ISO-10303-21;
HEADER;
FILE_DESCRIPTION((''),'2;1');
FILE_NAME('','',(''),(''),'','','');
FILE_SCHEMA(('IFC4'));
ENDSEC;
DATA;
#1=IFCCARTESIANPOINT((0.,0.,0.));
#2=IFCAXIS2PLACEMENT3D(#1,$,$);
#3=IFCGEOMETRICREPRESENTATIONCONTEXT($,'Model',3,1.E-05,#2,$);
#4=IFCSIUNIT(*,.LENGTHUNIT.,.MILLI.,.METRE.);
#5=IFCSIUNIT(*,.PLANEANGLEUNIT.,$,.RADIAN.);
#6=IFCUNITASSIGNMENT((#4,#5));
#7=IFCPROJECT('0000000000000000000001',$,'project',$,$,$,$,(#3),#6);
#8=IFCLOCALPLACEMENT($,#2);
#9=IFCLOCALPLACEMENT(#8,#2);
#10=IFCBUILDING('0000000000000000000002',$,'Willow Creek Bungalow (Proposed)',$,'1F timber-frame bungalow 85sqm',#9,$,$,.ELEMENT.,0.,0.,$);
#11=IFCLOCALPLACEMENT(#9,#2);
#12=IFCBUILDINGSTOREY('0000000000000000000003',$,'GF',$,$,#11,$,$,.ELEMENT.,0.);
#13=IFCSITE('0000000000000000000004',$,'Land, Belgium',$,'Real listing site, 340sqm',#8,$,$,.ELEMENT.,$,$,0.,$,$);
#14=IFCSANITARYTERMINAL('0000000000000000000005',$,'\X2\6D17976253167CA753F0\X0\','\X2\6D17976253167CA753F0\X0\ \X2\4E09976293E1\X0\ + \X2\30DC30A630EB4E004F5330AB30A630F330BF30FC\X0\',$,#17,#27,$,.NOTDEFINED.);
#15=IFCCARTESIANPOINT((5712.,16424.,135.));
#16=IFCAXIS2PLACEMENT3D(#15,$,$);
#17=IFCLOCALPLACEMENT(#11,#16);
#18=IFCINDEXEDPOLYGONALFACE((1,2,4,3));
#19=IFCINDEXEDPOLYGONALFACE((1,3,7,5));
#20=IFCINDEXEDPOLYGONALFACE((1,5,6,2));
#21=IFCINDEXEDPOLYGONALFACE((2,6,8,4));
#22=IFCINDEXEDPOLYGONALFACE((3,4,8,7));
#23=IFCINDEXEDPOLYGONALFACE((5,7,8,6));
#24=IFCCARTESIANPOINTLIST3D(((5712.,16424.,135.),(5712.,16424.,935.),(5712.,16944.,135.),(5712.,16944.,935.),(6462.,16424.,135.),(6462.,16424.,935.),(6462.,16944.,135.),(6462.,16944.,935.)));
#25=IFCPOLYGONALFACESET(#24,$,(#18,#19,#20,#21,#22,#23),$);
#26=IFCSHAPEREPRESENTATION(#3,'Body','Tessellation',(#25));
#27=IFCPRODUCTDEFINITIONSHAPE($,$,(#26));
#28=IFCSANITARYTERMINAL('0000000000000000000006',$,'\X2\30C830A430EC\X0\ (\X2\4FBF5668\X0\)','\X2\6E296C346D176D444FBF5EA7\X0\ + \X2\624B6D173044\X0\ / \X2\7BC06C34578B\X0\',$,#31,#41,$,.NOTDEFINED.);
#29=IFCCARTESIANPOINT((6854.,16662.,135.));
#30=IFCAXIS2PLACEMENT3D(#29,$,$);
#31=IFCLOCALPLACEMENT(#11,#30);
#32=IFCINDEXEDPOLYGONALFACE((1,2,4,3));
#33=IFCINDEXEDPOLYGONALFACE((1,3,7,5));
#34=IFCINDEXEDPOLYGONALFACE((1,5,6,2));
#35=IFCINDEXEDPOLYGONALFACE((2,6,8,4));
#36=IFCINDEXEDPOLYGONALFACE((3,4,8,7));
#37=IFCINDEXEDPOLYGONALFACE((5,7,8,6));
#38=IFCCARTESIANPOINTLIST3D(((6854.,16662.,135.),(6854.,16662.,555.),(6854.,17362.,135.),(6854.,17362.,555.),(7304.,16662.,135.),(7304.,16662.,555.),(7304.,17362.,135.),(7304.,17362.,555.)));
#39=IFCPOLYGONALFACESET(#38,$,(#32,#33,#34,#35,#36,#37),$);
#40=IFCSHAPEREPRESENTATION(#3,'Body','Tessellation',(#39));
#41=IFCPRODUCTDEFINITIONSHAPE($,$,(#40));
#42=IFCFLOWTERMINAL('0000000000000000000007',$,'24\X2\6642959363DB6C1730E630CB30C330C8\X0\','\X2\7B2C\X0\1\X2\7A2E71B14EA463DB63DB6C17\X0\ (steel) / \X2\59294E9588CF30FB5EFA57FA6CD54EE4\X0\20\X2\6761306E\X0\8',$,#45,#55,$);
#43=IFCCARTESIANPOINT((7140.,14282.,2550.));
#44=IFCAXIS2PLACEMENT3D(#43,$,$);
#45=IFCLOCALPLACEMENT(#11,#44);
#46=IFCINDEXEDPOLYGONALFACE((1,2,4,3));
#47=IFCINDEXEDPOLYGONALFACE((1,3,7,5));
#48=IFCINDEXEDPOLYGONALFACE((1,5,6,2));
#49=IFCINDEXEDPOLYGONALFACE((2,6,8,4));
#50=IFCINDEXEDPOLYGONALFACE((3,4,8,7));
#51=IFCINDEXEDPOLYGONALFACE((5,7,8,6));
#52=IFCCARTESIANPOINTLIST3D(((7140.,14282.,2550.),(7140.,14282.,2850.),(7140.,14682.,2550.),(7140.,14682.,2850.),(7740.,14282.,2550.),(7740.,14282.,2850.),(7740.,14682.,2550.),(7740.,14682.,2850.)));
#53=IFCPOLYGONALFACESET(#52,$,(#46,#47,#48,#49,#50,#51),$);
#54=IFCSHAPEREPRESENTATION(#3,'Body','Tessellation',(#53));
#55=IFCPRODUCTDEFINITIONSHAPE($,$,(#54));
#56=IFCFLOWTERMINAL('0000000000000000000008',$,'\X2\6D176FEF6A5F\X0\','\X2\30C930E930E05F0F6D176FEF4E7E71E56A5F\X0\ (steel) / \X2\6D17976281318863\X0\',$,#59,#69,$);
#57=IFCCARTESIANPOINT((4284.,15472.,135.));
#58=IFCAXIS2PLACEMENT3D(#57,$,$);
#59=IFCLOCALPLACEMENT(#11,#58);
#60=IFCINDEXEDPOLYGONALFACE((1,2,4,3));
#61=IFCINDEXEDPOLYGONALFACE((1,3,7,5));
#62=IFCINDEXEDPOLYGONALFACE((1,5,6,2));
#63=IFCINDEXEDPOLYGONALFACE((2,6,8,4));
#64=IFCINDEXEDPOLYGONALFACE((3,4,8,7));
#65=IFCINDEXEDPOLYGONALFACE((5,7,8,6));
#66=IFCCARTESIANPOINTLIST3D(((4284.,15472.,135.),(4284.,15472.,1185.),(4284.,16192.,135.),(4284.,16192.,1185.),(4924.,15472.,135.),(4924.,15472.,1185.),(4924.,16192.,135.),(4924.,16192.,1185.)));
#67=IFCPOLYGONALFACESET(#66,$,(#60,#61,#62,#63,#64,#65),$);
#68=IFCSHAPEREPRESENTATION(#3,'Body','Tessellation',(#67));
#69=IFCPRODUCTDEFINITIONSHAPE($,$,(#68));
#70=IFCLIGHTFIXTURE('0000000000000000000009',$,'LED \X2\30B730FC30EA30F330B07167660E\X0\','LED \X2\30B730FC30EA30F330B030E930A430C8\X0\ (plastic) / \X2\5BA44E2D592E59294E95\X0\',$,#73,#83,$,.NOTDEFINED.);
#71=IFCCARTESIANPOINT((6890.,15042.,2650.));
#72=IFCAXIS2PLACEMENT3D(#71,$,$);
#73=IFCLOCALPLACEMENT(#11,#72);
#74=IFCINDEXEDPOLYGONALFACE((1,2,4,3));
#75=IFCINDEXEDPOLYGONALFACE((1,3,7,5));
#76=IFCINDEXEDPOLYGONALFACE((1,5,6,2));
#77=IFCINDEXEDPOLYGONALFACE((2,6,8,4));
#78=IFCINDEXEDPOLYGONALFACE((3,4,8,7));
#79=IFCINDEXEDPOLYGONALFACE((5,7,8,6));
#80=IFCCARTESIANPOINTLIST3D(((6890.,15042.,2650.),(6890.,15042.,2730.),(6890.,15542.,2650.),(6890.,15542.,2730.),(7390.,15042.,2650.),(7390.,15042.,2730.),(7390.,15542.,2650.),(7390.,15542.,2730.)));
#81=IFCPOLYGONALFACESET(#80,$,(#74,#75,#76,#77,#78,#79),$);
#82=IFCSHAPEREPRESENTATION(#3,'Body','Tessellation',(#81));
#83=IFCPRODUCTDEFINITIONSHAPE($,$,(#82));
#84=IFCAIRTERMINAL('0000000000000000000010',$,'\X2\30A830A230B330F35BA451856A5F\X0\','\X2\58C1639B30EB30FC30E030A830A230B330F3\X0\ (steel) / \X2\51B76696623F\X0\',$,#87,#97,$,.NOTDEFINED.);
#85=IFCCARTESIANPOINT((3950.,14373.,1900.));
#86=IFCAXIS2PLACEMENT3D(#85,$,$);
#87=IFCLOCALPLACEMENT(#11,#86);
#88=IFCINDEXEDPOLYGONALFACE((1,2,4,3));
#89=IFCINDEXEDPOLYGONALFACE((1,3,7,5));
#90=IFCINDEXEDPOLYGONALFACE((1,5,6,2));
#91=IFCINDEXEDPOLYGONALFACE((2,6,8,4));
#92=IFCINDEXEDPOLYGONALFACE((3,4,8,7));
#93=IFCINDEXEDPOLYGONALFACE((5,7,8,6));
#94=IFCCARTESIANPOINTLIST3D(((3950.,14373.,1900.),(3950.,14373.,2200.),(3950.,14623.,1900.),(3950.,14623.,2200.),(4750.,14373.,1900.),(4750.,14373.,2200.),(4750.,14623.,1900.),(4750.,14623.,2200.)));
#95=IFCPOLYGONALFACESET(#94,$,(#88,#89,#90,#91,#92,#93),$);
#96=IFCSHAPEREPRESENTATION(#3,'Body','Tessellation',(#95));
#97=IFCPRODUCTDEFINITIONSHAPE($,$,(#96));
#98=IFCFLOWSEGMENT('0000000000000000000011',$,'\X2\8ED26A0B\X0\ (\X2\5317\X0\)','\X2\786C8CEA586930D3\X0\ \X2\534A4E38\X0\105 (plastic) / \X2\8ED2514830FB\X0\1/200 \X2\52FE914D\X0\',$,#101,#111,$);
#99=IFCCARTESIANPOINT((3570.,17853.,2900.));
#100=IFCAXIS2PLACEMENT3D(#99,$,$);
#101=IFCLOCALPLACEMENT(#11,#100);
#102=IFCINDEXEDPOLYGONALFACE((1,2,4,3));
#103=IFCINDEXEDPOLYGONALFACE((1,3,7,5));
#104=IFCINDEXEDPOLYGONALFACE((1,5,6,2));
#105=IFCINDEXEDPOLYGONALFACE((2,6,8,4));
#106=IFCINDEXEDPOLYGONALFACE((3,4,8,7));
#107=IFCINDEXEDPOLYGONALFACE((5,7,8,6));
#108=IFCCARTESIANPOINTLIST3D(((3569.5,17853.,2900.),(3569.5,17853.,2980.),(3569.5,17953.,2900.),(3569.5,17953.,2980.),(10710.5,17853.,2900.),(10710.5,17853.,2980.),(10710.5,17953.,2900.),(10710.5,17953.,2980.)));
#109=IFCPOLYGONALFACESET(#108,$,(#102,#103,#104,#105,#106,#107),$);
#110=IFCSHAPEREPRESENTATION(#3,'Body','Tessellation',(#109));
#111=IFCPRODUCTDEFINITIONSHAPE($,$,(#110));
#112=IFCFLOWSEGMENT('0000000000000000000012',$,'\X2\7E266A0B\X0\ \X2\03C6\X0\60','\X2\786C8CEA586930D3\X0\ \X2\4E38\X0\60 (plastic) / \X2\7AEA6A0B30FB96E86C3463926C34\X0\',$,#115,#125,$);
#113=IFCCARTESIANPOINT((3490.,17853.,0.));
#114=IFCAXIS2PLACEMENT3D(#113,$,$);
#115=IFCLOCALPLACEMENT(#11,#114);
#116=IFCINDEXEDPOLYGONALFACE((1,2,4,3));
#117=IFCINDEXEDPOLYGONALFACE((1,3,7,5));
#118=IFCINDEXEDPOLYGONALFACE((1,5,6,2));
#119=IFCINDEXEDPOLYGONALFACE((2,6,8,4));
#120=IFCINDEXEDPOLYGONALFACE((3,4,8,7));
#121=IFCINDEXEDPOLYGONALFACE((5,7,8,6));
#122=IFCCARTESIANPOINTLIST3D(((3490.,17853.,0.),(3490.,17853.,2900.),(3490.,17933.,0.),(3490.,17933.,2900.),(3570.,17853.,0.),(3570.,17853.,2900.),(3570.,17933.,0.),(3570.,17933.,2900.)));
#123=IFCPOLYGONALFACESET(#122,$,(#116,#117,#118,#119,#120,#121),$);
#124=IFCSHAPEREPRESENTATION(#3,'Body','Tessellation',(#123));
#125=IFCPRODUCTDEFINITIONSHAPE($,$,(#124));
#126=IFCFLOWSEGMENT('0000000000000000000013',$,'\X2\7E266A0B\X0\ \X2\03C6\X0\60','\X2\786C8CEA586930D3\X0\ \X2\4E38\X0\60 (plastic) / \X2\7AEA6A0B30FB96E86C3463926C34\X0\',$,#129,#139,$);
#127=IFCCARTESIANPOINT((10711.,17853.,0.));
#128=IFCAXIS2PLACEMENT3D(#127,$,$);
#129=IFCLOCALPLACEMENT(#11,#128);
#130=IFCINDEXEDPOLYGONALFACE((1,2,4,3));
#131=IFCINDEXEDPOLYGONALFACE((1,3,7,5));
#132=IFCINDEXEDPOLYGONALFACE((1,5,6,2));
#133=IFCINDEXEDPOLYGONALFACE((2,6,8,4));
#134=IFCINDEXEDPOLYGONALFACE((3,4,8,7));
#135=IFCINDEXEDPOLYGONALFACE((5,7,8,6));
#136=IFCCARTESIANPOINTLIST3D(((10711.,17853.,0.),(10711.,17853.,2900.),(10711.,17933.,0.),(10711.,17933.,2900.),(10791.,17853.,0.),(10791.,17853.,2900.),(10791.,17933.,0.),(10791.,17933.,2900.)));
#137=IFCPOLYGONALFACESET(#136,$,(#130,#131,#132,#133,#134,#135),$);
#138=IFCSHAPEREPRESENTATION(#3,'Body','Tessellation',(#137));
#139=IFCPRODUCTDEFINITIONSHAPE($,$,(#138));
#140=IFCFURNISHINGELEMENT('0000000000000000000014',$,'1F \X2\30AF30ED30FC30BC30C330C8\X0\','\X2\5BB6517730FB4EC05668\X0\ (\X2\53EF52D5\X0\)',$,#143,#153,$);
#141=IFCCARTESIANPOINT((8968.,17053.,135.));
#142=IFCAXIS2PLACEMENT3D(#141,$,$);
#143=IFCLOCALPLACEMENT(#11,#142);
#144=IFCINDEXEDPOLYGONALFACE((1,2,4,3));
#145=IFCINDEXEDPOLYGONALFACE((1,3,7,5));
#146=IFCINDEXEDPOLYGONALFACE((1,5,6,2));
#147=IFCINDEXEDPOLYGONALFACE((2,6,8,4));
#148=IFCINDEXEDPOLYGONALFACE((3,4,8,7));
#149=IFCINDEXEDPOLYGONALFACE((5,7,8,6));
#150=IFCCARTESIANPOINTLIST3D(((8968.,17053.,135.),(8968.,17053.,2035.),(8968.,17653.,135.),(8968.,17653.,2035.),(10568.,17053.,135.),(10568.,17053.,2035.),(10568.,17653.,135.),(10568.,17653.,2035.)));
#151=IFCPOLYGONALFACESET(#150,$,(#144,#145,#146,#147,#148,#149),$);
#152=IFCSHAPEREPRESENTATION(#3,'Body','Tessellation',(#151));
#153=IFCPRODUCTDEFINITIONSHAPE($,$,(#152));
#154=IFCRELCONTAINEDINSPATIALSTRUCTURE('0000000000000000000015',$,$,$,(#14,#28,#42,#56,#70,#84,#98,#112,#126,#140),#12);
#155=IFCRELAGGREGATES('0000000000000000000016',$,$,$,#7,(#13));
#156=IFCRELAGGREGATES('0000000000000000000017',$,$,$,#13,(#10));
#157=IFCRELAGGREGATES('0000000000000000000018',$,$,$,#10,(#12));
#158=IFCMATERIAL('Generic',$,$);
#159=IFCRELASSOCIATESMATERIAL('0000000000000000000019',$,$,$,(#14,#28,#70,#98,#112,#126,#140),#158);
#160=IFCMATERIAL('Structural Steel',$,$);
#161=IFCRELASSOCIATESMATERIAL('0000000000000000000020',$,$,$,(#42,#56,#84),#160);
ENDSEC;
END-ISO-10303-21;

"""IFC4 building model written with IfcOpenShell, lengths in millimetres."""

from ifc_helpers import new_model, si_unit, frame, frame_2d, origin, place, context, project, spatial, rectangle, extrude, material, element, save


model = new_model("IFC4")

# Units and contexts
model_context = context("Model", 3, precision=1e-05, world=origin())
ifc_project = project(units=[si_unit("LENGTHUNIT", "METRE", prefix="MILLI"), si_unit("PLANEANGLEUNIT", "RADIAN")], contexts=[model_context])

# Site, building, storey
site_placement = place(None, origin())
site = spatial("IfcSite", under=ifc_project, at=site_placement, Name="Land, Belgium", ObjectType="Real listing site, 340sqm", CompositionType="ELEMENT", RefElevation=0.0)
building_placement = place(site_placement, origin())
building = spatial("IfcBuilding", under=site, at=building_placement, Name="Willow Creek Bungalow (Proposed)", ObjectType="1F timber-frame bungalow 85sqm", CompositionType="ELEMENT", ElevationOfRefHeight=0.0, ElevationOfTerrain=0.0)
storey_placement = place(building_placement, origin())
storey = spatial("IfcBuildingStorey", under=building, at=storey_placement, Name="GF", CompositionType="ELEMENT", Elevation=0.0)

# Shared definitions
ifc_material_1 = material(Name="Generic")

# Sanitary terminals
sanitary_terminal_1_placement = place(storey_placement, frame((5712.0, 16424.0, 135.0)))
element("IfcSanitaryTerminal", 1, at=sanitary_terminal_1_placement, inside=storey, material=ifc_material_1, Name="洗面化粧台", Description="洗面化粧台 三面鏡 + ボウル一体カウンター", PredefinedType="NOTDEFINED", context=model_context, shape_type="SweptSolid", body=[
    extrude(rectangle(XDim=750.0, YDim=520.0, at=frame_2d((375.0, 260.0))), frame((5712.0, 16424.0, 135.0)), (0.0, 0.0, 1.0), 800.0),
])
sanitary_terminal_2_placement = place(storey_placement, frame((6854.0, 16662.0, 135.0)))
element("IfcSanitaryTerminal", 2, at=sanitary_terminal_2_placement, inside=storey, material=ifc_material_1, Name="トイレ (便器)", Description="温水洗浄便座 + 手洗い / 節水型", PredefinedType="NOTDEFINED", context=model_context, shape_type="SweptSolid", body=[
    extrude(rectangle(XDim=450.0, YDim=700.0, at=frame_2d((225.0, 350.0))), frame((6854.0, 16662.0, 135.0)), (0.0, 0.0, 1.0), 420.0),
])

# Flow terminals
ifc_material_2 = material(Name="Structural Steel")
flow_terminal_1_placement = place(storey_placement, frame((7140.0, 14282.0, 2550.0)))
element("IfcFlowTerminal", 3, at=flow_terminal_1_placement, inside=storey, material=ifc_material_2, Name="24時間換気ユニット", Description="第1種熱交換換気 (steel) / 天井裏・建基法令20条の8", context=model_context, shape_type="SweptSolid", body=[
    extrude(rectangle(XDim=600.0, YDim=400.0, at=frame_2d((300.0, 200.0))), frame((7140.0, 14282.0, 2550.0)), (0.0, 0.0, 1.0), 300.0),
])
flow_terminal_2_placement = place(storey_placement, frame((4284.0, 15472.0, 135.0)))
element("IfcFlowTerminal", 4, at=flow_terminal_2_placement, inside=storey, material=ifc_material_2, Name="洗濯機", Description="ドラム式洗濯乾燥機 (steel) / 洗面脱衣", context=model_context, shape_type="SweptSolid", body=[
    extrude(rectangle(XDim=640.0, YDim=720.0, at=frame_2d((320.0, 360.0))), frame((4284.0, 15472.0, 135.0)), (0.0, 0.0, 1.0), 1050.0),
])

# Light fixture
light_fixture_placement = place(storey_placement, frame((6890.0, 15042.0, 2650.0)))
element("IfcLightFixture", 5, at=light_fixture_placement, inside=storey, material=ifc_material_1, Name="LED シーリング照明", Description="LED シーリングライト (plastic) / 室中央天井", PredefinedType="NOTDEFINED", context=model_context, shape_type="SweptSolid", body=[
    extrude(rectangle(XDim=500.0, YDim=500.0, at=frame_2d((250.0, 250.0))), frame((6890.0, 15042.0, 2650.0)), (0.0, 0.0, 1.0), 80.0),
])

# Air terminal
air_terminal_placement = place(storey_placement, frame((3950.0, 14373.0, 1900.0)))
element("IfcAirTerminal", 6, at=air_terminal_placement, inside=storey, material=ifc_material_2, Name="エアコン室内機", Description="壁掛ルームエアコン (steel) / 冷暖房", PredefinedType="NOTDEFINED", context=model_context, shape_type="SweptSolid", body=[
    extrude(rectangle(XDim=800.0, YDim=250.0, at=frame_2d((400.0, 125.0))), frame((3950.0, 14373.0, 1900.0)), (0.0, 0.0, 1.0), 300.0),
])

# Flow segments
flow_segment_1_placement = place(storey_placement, frame((3570.0, 17853.0, 2900.0)))
element("IfcFlowSegment", 7, at=flow_segment_1_placement, inside=storey, material=ifc_material_1, Name="軒樋 (北)", Description="硬質塩ビ 半丸105 (plastic) / 軒先・1/200 勾配", context=model_context, shape_type="SweptSolid", body=[
    extrude(rectangle(XDim=7141.0, YDim=100.0, at=frame_2d((3570.0, 50.0))), frame((3570.0, 17853.0, 2900.0)), (0.0, 0.0, 1.0), 80.0),
])
flow_segment_2_placement = place(storey_placement, frame((3490.0, 17853.0, 0.0)))
element("IfcFlowSegment", 8, at=flow_segment_2_placement, inside=storey, material=ifc_material_1, Name="縦樋 φ60", Description="硬質塩ビ 丸60 (plastic) / 竪樋・雨水排水", context=model_context, shape_type="SweptSolid", body=[
    extrude(rectangle(XDim=80.0, YDim=80.0, at=frame_2d((40.0, 40.0))), frame((3490.0, 17853.0, 0.0)), (0.0, 0.0, 1.0), 2900.0),
])
flow_segment_3_placement = place(storey_placement, frame((10711.0, 17853.0, 0.0)))
element("IfcFlowSegment", 9, at=flow_segment_3_placement, inside=storey, material=ifc_material_1, Name="縦樋 φ60", Description="硬質塩ビ 丸60 (plastic) / 竪樋・雨水排水", context=model_context, shape_type="SweptSolid", body=[
    extrude(rectangle(XDim=80.0, YDim=80.0, at=frame_2d((40.0, 40.0))), frame((10711.0, 17853.0, 0.0)), (0.0, 0.0, 1.0), 2900.0),
])

# Furnishing element
furnishing_placement = place(storey_placement, frame((8968.0, 17053.0, 135.0)))
element("IfcFurnishingElement", 10, at=furnishing_placement, inside=storey, material=ifc_material_1, Name="1F クローゼット", Description="家具・什器 (可動)", context=model_context, shape_type="SweptSolid", body=[
    extrude(rectangle(XDim=1600.0, YDim=600.0, at=frame_2d((800.0, 300.0))), frame((8968.0, 17053.0, 135.0)), (0.0, 0.0, 1.0), 1900.0),
])

save(model, "model.ifc")
